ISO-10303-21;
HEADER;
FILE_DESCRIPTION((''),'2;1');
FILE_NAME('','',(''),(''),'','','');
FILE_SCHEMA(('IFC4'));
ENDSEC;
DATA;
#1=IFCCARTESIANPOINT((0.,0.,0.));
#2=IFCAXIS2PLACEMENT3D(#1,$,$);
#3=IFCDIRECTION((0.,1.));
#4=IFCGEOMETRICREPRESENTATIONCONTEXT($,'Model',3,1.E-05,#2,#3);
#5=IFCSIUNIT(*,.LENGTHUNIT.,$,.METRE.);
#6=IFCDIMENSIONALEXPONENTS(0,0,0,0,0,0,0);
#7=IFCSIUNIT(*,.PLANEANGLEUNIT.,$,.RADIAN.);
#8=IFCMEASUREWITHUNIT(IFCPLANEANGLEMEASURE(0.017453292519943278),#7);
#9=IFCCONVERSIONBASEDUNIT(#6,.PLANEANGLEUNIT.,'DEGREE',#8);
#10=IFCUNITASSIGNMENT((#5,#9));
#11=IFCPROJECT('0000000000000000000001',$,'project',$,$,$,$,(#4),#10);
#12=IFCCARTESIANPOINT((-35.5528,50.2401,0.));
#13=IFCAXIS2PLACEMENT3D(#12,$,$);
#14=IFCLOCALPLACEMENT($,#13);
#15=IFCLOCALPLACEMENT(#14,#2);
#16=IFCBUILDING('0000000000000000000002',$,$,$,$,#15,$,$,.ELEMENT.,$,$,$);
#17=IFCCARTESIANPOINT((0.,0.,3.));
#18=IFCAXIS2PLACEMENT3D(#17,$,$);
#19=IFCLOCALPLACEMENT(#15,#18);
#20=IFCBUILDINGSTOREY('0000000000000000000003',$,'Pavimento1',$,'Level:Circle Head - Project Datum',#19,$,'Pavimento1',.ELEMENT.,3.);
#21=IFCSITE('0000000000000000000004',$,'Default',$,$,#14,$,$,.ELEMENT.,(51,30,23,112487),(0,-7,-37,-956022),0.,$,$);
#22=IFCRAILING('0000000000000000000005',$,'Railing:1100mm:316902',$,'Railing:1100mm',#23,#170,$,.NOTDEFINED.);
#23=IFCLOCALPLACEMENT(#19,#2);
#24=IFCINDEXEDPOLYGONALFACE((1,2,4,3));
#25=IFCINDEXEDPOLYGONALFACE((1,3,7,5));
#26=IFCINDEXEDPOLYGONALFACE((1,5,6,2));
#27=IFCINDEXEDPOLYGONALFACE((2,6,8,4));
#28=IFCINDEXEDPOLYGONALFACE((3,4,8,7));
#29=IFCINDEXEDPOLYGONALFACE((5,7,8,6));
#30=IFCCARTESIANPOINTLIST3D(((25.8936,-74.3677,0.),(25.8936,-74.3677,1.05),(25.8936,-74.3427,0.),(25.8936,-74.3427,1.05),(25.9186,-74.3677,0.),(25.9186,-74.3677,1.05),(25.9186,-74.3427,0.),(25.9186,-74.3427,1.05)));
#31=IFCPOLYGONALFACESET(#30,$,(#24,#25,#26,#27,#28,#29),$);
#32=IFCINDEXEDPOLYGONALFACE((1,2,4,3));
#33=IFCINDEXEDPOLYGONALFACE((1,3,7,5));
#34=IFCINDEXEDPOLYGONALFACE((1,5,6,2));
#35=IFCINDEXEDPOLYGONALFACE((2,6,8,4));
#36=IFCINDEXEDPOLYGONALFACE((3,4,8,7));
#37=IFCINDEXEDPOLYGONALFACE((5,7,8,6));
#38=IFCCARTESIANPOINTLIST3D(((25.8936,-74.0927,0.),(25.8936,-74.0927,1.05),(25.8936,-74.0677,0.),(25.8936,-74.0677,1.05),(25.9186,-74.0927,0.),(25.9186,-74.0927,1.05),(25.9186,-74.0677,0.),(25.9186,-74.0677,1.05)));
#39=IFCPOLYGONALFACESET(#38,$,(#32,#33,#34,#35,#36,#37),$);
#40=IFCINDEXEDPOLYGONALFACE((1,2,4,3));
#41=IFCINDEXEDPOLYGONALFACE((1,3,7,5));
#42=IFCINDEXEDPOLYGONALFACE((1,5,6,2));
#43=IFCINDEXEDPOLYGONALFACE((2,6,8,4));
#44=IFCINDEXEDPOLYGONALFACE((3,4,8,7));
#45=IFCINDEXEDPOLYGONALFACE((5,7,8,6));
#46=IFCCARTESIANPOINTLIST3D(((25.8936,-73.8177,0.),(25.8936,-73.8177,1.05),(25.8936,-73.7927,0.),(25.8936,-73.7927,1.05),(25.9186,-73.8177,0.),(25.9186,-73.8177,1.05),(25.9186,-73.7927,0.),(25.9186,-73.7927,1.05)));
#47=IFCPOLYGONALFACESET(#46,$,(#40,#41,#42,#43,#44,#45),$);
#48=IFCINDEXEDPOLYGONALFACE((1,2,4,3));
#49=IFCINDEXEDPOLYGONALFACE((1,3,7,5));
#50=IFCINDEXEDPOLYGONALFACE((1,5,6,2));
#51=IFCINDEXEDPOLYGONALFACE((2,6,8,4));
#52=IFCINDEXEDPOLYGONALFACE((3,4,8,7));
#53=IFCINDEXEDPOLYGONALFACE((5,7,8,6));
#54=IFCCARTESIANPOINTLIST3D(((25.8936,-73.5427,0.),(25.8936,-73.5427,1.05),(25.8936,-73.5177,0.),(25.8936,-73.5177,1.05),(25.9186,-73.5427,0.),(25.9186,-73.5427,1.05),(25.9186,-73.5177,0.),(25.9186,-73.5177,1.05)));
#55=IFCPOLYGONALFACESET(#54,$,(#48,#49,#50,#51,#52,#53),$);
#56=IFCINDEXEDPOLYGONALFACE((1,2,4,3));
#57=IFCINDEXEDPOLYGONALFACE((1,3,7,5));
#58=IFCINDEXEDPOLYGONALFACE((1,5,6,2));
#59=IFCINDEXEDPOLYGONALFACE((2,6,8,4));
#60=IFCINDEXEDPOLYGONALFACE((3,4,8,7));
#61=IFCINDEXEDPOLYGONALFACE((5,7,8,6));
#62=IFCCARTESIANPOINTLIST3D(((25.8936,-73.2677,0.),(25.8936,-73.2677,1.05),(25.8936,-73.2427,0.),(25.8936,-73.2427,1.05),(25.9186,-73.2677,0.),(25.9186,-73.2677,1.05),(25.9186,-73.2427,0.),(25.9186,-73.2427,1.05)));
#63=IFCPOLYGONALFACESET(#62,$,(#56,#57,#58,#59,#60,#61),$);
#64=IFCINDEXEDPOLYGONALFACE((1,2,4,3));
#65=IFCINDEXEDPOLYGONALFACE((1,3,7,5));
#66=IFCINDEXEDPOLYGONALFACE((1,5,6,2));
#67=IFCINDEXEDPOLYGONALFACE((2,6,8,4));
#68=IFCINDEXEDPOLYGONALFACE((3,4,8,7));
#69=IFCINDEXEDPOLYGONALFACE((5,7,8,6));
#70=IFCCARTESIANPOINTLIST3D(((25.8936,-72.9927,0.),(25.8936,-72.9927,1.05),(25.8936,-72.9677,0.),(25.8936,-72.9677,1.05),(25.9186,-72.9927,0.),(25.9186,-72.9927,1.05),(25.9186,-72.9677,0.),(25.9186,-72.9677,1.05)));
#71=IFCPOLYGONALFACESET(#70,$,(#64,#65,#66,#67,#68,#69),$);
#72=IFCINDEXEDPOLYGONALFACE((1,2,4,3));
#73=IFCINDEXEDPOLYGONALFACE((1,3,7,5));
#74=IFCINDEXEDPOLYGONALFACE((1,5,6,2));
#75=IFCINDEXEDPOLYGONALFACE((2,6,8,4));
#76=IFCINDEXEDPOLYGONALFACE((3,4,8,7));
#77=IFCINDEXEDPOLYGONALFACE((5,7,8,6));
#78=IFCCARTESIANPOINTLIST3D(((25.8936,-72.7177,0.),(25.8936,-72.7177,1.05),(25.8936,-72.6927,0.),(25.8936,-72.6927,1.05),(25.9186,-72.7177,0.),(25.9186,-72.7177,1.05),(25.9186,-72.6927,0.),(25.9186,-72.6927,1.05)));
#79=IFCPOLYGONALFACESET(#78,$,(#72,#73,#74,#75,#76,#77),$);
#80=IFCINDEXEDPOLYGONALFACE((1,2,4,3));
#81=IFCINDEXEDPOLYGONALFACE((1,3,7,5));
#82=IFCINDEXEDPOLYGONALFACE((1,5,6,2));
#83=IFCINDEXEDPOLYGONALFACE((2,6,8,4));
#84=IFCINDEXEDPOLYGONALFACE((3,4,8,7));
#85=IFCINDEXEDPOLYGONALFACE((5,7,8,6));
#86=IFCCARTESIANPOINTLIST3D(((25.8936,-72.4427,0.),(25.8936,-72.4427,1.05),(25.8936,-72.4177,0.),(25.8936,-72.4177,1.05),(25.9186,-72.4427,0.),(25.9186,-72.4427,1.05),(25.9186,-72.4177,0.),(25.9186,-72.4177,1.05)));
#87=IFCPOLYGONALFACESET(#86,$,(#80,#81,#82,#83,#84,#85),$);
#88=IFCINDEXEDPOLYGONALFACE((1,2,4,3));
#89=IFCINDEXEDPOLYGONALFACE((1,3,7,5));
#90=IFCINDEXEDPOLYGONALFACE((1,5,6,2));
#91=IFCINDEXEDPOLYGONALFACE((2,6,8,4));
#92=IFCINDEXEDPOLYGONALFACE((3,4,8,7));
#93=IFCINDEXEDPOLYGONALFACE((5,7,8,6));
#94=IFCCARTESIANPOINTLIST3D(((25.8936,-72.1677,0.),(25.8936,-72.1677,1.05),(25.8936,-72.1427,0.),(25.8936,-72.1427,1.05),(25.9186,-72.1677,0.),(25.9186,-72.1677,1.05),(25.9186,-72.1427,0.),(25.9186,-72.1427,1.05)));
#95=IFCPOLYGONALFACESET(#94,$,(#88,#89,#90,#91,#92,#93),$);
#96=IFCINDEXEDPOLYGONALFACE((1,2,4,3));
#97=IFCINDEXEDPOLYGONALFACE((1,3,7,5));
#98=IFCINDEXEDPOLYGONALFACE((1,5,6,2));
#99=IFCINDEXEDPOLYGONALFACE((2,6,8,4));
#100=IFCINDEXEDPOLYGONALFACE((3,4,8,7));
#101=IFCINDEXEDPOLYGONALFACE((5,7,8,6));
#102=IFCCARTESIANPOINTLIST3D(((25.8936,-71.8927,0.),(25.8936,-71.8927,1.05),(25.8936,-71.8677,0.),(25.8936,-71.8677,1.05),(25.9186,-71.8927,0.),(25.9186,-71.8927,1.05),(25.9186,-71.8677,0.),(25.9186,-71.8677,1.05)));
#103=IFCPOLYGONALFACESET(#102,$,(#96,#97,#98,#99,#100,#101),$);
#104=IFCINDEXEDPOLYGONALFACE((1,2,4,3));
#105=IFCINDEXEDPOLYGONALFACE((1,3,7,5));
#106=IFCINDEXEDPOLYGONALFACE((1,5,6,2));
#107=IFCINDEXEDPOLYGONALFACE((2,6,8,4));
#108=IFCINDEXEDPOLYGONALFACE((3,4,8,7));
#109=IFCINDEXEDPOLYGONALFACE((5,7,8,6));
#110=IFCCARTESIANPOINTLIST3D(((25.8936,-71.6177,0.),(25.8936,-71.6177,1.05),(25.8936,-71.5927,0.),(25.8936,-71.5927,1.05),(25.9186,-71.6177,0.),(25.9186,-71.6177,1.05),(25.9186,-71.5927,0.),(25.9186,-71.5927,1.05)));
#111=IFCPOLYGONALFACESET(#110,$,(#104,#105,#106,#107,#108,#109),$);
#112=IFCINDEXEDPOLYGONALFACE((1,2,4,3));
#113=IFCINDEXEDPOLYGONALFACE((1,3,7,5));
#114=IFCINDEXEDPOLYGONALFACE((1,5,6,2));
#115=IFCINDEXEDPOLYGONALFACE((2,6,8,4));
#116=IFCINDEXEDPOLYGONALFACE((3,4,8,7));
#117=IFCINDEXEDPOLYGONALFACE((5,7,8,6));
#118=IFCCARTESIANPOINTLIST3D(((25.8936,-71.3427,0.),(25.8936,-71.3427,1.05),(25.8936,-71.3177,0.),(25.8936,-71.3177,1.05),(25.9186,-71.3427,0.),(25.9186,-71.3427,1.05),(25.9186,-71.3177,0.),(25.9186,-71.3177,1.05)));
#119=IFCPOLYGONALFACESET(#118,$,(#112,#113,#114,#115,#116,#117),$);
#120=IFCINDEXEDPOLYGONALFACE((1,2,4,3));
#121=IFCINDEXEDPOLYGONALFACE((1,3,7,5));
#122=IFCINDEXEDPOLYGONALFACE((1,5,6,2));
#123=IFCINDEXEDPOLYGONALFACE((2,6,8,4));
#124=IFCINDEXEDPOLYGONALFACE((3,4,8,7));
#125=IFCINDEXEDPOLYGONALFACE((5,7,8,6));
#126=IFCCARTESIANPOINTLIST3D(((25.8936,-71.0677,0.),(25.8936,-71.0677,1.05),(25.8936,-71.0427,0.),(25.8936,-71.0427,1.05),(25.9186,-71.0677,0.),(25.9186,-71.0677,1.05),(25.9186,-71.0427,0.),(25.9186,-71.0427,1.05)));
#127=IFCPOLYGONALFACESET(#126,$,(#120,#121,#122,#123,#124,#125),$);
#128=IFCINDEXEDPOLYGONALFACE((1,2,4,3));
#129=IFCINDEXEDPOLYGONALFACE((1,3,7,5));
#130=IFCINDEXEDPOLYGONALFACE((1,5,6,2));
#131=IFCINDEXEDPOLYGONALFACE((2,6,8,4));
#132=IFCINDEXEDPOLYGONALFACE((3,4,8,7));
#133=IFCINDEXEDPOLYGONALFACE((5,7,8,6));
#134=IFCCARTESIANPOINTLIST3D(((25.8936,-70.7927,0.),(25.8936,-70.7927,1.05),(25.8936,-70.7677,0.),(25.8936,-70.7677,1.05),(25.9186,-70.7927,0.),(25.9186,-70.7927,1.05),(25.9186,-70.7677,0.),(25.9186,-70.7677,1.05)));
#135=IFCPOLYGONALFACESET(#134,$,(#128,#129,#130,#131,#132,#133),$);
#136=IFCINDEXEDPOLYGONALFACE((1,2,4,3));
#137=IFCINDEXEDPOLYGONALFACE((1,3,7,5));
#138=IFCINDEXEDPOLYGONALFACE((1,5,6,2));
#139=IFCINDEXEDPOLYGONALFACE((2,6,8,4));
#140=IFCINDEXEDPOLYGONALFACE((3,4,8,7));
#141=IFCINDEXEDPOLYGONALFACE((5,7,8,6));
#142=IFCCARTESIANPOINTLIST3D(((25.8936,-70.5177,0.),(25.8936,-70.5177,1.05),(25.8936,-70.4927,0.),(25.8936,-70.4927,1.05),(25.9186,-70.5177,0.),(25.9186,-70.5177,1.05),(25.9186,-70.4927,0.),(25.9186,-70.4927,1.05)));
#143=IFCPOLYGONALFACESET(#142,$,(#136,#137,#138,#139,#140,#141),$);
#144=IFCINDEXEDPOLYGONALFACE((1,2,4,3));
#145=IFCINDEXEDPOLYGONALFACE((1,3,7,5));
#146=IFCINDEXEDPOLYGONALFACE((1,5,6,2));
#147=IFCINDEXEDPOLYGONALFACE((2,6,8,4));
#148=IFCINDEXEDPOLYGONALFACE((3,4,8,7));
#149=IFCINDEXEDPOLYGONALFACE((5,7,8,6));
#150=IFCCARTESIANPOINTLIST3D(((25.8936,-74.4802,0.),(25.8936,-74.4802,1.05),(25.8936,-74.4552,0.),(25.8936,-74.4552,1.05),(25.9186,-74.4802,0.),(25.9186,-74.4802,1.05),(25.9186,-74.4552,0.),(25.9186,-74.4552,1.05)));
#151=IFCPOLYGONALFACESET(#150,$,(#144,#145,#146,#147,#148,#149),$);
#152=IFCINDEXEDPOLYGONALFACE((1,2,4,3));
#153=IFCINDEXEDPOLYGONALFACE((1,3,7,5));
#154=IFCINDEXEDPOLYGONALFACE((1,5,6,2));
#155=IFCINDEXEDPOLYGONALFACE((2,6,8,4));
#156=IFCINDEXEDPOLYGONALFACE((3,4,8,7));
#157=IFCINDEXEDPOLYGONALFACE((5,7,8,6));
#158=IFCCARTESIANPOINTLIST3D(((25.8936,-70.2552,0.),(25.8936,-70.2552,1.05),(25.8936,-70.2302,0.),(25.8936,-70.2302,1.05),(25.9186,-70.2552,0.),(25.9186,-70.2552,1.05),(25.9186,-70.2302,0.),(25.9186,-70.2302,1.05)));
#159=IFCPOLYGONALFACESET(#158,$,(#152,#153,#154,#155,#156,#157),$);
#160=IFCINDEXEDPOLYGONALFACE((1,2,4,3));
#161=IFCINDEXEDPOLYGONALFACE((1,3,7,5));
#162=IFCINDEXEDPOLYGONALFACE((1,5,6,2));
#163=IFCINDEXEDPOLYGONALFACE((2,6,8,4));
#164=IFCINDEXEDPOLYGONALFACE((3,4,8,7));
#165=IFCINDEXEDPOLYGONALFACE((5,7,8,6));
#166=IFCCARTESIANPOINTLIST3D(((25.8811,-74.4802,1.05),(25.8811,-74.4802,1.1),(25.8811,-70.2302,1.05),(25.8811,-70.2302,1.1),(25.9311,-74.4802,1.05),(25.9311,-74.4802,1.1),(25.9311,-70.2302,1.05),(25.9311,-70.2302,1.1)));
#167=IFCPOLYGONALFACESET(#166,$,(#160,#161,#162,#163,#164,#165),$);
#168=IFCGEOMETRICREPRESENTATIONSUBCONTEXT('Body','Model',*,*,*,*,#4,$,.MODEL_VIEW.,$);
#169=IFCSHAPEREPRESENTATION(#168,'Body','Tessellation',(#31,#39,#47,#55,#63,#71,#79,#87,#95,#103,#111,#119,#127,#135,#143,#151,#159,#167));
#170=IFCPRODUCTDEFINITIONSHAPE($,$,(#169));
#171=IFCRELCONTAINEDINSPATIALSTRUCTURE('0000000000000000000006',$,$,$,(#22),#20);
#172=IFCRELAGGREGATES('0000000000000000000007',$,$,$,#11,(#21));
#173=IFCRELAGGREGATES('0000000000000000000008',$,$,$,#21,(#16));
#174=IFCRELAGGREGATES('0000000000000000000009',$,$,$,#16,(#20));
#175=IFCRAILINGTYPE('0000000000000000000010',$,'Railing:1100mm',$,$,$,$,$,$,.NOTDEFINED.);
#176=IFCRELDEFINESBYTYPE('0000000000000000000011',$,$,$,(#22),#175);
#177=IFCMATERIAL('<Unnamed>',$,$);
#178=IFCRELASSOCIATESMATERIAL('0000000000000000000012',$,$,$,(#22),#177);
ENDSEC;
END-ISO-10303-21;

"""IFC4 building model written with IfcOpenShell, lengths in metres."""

from ifc_helpers import new_model, entity, si_unit, converted_unit, direction, frame, origin, place, context, subcontext, project, spatial, indexed_curve, outline, extrude, material, type_object, element, save


model = new_model("IFC4")

# Units and contexts
model_context = context("Model", 3, precision=1e-05, world=origin(), true_north=direction((0.0, 1.0)))
body_context = subcontext(model_context, "Body", "Model", "MODEL_VIEW")
ifc_project = project(units=[si_unit("LENGTHUNIT", "METRE"), converted_unit("PLANEANGLEUNIT", "DEGREE", entity("IfcPlaneAngleMeasure", 0.017453292519943278), si_unit("PLANEANGLEUNIT", "RADIAN"), dimensions=[0, 0, 0, 0, 0, 0, 0])], contexts=[model_context])

# Site, building, storey
site_placement = place(None, frame((-35.5528, 50.2401, 0.0)))
site = spatial("IfcSite", under=ifc_project, at=site_placement, Name="Default", CompositionType="ELEMENT", RefLatitude=(51, 30, 23, 112487), RefLongitude=(0, -7, -37, -956022), RefElevation=0.0)
building_placement = place(site_placement, origin())
building = spatial("IfcBuilding", under=site, at=building_placement, CompositionType="ELEMENT")
storey_placement = place(building_placement, frame((0.0, 0.0, 3.0)))
storey = spatial("IfcBuildingStorey", under=building, at=storey_placement, Name="Pavimento1", ObjectType="Level:Circle Head - Project Datum", LongName="Pavimento1", CompositionType="ELEMENT", Elevation=3.0)

# Railing
ifc_material_1 = material(Name="<Unnamed>")
railing_type = type_object("IfcRailingType", Name="Railing:1100mm", PredefinedType="NOTDEFINED")
railing_1_placement = place(storey_placement, origin())
element("IfcRailing", 1, at=railing_1_placement, inside=storey, type_object=railing_type, material=ifc_material_1, Name="Railing:1100mm:316902", ObjectType="Railing:1100mm", PredefinedType="NOTDEFINED", context=body_context, shape_type="SweptSolid", body=[
    extrude(outline(indexed_curve([(-0.0125, -0.0125), (0.0125, -0.0125), (0.0125, 0.0125), (-0.0125, 0.0125), (-0.0125, -0.0125)], self_intersect=False)), frame((25.9061, -74.3552, 0.0), z_axis=(0.0, 0.0, 1.0), x_axis=(0.0, -1.0, 0.0)), (0.0, 0.0, 1.0), 1.05),
    extrude(outline(indexed_curve([(-0.0125, -0.0125), (0.0125, -0.0125), (0.0125, 0.0125), (-0.0125, 0.0125), (-0.0125, -0.0125)], self_intersect=False)), frame((25.9061, -74.0802, 0.0), z_axis=(0.0, 0.0, 1.0), x_axis=(0.0, -1.0, 0.0)), (0.0, 0.0, 1.0), 1.05),
    extrude(outline(indexed_curve([(-0.0125, -0.0125), (0.0125, -0.0125), (0.0125, 0.0125), (-0.0125, 0.0125), (-0.0125, -0.0125)], self_intersect=False)), frame((25.9061, -73.8052, 0.0), z_axis=(0.0, 0.0, 1.0), x_axis=(0.0, -1.0, 0.0)), (0.0, 0.0, 1.0), 1.05),
    extrude(outline(indexed_curve([(-0.0125, -0.0125), (0.0125, -0.0125), (0.0125, 0.0125), (-0.0125, 0.0125), (-0.0125, -0.0125)], self_intersect=False)), frame((25.9061, -73.5302, 0.0), z_axis=(0.0, 0.0, 1.0), x_axis=(0.0, -1.0, 0.0)), (0.0, 0.0, 1.0), 1.05),
    extrude(outline(indexed_curve([(-0.0125, -0.0125), (0.0125, -0.0125), (0.0125, 0.0125), (-0.0125, 0.0125), (-0.0125, -0.0125)], self_intersect=False)), frame((25.9061, -73.2552, 0.0), z_axis=(0.0, 0.0, 1.0), x_axis=(0.0, -1.0, 0.0)), (0.0, 0.0, 1.0), 1.05),
    extrude(outline(indexed_curve([(-0.0125, -0.0125), (0.0125, -0.0125), (0.0125, 0.0125), (-0.0125, 0.0125), (-0.0125, -0.0125)], self_intersect=False)), frame((25.9061, -72.9802, 0.0), z_axis=(0.0, 0.0, 1.0), x_axis=(0.0, -1.0, 0.0)), (0.0, 0.0, 1.0), 1.05),
    extrude(outline(indexed_curve([(-0.0125, -0.0125), (0.0125, -0.0125), (0.0125, 0.0125), (-0.0125, 0.0125), (-0.0125, -0.0125)], self_intersect=False)), frame((25.9061, -72.7052, 0.0), z_axis=(0.0, 0.0, 1.0), x_axis=(0.0, -1.0, 0.0)), (0.0, 0.0, 1.0), 1.05),
    extrude(outline(indexed_curve([(-0.0125, -0.0125), (0.0125, -0.0125), (0.0125, 0.0125), (-0.0125, 0.0125), (-0.0125, -0.0125)], self_intersect=False)), frame((25.9061, -72.4302, 0.0), z_axis=(0.0, 0.0, 1.0), x_axis=(0.0, -1.0, 0.0)), (0.0, 0.0, 1.0), 1.05),
    extrude(outline(indexed_curve([(-0.0125, -0.0125), (0.0125, -0.0125), (0.0125, 0.0125), (-0.0125, 0.0125), (-0.0125, -0.0125)], self_intersect=False)), frame((25.9061, -72.1552, 0.0), z_axis=(0.0, 0.0, 1.0), x_axis=(0.0, -1.0, 0.0)), (0.0, 0.0, 1.0), 1.05),
    extrude(outline(indexed_curve([(-0.0125, -0.0125), (0.0125, -0.0125), (0.0125, 0.0125), (-0.0125, 0.0125), (-0.0125, -0.0125)], self_intersect=False)), frame((25.9061, -71.8802, 0.0), z_axis=(0.0, 0.0, 1.0), x_axis=(0.0, -1.0, 0.0)), (0.0, 0.0, 1.0), 1.05),
    extrude(outline(indexed_curve([(-0.0125, -0.0125), (0.0125, -0.0125), (0.0125, 0.0125), (-0.0125, 0.0125), (-0.0125, -0.0125)], self_intersect=False)), frame((25.9061, -71.6052, 0.0), z_axis=(0.0, 0.0, 1.0), x_axis=(0.0, -1.0, 0.0)), (0.0, 0.0, 1.0), 1.05),
    extrude(outline(indexed_curve([(-0.0125, -0.0125), (0.0125, -0.0125), (0.0125, 0.0125), (-0.0125, 0.0125), (-0.0125, -0.0125)], self_intersect=False)), frame((25.9061, -71.3302, 0.0), z_axis=(0.0, 0.0, 1.0), x_axis=(0.0, -1.0, 0.0)), (0.0, 0.0, 1.0), 1.05),
    extrude(outline(indexed_curve([(-0.0125, -0.0125), (0.0125, -0.0125), (0.0125, 0.0125), (-0.0125, 0.0125), (-0.0125, -0.0125)], self_intersect=False)), frame((25.9061, -71.0552, 0.0), z_axis=(0.0, 0.0, 1.0), x_axis=(0.0, -1.0, 0.0)), (0.0, 0.0, 1.0), 1.05),
    extrude(outline(indexed_curve([(-0.0125, -0.0125), (0.0125, -0.0125), (0.0125, 0.0125), (-0.0125, 0.0125), (-0.0125, -0.0125)], self_intersect=False)), frame((25.9061, -70.7802, 0.0), z_axis=(0.0, 0.0, 1.0), x_axis=(0.0, -1.0, 0.0)), (0.0, 0.0, 1.0), 1.05),
    extrude(outline(indexed_curve([(-0.0125, -0.0125), (0.0125, -0.0125), (0.0125, 0.0125), (-0.0125, 0.0125), (-0.0125, -0.0125)], self_intersect=False)), frame((25.9061, -70.5052, 0.0), z_axis=(0.0, 0.0, 1.0), x_axis=(0.0, -1.0, 0.0)), (0.0, 0.0, 1.0), 1.05),
    extrude(outline(indexed_curve([(-0.0125, -0.0125), (0.0125, -0.0125), (0.0125, 0.0125), (-0.0125, 0.0125), (-0.0125, -0.0125)], self_intersect=False)), frame((25.9061, -74.4677, 0.0), z_axis=(0.0, 0.0, 1.0), x_axis=(0.0, -1.0, 0.0)), (0.0, 0.0, 1.0), 1.05),
    extrude(outline(indexed_curve([(-0.0125, -0.0125), (0.0125, -0.0125), (0.0125, 0.0125), (-0.0125, 0.0125), (-0.0125, -0.0125)], self_intersect=False)), frame((25.9061, -70.2427, 0.0), z_axis=(0.0, 0.0, 1.0), x_axis=(0.0, -1.0, 0.0)), (0.0, 0.0, 1.0), 1.05),
    extrude(outline(indexed_curve([(-2.125, -0.025), (2.125, -0.025), (2.125, 0.025), (-2.125, 0.025), (-2.125, -0.025)], self_intersect=False)), frame((25.9061, -72.3552, 1.05), z_axis=(0.0, 0.0, 1.0), x_axis=(0.0, -1.0, 0.0)), (0.0, 0.0, 1.0), 0.05),
])

save(model, "model.ifc")
